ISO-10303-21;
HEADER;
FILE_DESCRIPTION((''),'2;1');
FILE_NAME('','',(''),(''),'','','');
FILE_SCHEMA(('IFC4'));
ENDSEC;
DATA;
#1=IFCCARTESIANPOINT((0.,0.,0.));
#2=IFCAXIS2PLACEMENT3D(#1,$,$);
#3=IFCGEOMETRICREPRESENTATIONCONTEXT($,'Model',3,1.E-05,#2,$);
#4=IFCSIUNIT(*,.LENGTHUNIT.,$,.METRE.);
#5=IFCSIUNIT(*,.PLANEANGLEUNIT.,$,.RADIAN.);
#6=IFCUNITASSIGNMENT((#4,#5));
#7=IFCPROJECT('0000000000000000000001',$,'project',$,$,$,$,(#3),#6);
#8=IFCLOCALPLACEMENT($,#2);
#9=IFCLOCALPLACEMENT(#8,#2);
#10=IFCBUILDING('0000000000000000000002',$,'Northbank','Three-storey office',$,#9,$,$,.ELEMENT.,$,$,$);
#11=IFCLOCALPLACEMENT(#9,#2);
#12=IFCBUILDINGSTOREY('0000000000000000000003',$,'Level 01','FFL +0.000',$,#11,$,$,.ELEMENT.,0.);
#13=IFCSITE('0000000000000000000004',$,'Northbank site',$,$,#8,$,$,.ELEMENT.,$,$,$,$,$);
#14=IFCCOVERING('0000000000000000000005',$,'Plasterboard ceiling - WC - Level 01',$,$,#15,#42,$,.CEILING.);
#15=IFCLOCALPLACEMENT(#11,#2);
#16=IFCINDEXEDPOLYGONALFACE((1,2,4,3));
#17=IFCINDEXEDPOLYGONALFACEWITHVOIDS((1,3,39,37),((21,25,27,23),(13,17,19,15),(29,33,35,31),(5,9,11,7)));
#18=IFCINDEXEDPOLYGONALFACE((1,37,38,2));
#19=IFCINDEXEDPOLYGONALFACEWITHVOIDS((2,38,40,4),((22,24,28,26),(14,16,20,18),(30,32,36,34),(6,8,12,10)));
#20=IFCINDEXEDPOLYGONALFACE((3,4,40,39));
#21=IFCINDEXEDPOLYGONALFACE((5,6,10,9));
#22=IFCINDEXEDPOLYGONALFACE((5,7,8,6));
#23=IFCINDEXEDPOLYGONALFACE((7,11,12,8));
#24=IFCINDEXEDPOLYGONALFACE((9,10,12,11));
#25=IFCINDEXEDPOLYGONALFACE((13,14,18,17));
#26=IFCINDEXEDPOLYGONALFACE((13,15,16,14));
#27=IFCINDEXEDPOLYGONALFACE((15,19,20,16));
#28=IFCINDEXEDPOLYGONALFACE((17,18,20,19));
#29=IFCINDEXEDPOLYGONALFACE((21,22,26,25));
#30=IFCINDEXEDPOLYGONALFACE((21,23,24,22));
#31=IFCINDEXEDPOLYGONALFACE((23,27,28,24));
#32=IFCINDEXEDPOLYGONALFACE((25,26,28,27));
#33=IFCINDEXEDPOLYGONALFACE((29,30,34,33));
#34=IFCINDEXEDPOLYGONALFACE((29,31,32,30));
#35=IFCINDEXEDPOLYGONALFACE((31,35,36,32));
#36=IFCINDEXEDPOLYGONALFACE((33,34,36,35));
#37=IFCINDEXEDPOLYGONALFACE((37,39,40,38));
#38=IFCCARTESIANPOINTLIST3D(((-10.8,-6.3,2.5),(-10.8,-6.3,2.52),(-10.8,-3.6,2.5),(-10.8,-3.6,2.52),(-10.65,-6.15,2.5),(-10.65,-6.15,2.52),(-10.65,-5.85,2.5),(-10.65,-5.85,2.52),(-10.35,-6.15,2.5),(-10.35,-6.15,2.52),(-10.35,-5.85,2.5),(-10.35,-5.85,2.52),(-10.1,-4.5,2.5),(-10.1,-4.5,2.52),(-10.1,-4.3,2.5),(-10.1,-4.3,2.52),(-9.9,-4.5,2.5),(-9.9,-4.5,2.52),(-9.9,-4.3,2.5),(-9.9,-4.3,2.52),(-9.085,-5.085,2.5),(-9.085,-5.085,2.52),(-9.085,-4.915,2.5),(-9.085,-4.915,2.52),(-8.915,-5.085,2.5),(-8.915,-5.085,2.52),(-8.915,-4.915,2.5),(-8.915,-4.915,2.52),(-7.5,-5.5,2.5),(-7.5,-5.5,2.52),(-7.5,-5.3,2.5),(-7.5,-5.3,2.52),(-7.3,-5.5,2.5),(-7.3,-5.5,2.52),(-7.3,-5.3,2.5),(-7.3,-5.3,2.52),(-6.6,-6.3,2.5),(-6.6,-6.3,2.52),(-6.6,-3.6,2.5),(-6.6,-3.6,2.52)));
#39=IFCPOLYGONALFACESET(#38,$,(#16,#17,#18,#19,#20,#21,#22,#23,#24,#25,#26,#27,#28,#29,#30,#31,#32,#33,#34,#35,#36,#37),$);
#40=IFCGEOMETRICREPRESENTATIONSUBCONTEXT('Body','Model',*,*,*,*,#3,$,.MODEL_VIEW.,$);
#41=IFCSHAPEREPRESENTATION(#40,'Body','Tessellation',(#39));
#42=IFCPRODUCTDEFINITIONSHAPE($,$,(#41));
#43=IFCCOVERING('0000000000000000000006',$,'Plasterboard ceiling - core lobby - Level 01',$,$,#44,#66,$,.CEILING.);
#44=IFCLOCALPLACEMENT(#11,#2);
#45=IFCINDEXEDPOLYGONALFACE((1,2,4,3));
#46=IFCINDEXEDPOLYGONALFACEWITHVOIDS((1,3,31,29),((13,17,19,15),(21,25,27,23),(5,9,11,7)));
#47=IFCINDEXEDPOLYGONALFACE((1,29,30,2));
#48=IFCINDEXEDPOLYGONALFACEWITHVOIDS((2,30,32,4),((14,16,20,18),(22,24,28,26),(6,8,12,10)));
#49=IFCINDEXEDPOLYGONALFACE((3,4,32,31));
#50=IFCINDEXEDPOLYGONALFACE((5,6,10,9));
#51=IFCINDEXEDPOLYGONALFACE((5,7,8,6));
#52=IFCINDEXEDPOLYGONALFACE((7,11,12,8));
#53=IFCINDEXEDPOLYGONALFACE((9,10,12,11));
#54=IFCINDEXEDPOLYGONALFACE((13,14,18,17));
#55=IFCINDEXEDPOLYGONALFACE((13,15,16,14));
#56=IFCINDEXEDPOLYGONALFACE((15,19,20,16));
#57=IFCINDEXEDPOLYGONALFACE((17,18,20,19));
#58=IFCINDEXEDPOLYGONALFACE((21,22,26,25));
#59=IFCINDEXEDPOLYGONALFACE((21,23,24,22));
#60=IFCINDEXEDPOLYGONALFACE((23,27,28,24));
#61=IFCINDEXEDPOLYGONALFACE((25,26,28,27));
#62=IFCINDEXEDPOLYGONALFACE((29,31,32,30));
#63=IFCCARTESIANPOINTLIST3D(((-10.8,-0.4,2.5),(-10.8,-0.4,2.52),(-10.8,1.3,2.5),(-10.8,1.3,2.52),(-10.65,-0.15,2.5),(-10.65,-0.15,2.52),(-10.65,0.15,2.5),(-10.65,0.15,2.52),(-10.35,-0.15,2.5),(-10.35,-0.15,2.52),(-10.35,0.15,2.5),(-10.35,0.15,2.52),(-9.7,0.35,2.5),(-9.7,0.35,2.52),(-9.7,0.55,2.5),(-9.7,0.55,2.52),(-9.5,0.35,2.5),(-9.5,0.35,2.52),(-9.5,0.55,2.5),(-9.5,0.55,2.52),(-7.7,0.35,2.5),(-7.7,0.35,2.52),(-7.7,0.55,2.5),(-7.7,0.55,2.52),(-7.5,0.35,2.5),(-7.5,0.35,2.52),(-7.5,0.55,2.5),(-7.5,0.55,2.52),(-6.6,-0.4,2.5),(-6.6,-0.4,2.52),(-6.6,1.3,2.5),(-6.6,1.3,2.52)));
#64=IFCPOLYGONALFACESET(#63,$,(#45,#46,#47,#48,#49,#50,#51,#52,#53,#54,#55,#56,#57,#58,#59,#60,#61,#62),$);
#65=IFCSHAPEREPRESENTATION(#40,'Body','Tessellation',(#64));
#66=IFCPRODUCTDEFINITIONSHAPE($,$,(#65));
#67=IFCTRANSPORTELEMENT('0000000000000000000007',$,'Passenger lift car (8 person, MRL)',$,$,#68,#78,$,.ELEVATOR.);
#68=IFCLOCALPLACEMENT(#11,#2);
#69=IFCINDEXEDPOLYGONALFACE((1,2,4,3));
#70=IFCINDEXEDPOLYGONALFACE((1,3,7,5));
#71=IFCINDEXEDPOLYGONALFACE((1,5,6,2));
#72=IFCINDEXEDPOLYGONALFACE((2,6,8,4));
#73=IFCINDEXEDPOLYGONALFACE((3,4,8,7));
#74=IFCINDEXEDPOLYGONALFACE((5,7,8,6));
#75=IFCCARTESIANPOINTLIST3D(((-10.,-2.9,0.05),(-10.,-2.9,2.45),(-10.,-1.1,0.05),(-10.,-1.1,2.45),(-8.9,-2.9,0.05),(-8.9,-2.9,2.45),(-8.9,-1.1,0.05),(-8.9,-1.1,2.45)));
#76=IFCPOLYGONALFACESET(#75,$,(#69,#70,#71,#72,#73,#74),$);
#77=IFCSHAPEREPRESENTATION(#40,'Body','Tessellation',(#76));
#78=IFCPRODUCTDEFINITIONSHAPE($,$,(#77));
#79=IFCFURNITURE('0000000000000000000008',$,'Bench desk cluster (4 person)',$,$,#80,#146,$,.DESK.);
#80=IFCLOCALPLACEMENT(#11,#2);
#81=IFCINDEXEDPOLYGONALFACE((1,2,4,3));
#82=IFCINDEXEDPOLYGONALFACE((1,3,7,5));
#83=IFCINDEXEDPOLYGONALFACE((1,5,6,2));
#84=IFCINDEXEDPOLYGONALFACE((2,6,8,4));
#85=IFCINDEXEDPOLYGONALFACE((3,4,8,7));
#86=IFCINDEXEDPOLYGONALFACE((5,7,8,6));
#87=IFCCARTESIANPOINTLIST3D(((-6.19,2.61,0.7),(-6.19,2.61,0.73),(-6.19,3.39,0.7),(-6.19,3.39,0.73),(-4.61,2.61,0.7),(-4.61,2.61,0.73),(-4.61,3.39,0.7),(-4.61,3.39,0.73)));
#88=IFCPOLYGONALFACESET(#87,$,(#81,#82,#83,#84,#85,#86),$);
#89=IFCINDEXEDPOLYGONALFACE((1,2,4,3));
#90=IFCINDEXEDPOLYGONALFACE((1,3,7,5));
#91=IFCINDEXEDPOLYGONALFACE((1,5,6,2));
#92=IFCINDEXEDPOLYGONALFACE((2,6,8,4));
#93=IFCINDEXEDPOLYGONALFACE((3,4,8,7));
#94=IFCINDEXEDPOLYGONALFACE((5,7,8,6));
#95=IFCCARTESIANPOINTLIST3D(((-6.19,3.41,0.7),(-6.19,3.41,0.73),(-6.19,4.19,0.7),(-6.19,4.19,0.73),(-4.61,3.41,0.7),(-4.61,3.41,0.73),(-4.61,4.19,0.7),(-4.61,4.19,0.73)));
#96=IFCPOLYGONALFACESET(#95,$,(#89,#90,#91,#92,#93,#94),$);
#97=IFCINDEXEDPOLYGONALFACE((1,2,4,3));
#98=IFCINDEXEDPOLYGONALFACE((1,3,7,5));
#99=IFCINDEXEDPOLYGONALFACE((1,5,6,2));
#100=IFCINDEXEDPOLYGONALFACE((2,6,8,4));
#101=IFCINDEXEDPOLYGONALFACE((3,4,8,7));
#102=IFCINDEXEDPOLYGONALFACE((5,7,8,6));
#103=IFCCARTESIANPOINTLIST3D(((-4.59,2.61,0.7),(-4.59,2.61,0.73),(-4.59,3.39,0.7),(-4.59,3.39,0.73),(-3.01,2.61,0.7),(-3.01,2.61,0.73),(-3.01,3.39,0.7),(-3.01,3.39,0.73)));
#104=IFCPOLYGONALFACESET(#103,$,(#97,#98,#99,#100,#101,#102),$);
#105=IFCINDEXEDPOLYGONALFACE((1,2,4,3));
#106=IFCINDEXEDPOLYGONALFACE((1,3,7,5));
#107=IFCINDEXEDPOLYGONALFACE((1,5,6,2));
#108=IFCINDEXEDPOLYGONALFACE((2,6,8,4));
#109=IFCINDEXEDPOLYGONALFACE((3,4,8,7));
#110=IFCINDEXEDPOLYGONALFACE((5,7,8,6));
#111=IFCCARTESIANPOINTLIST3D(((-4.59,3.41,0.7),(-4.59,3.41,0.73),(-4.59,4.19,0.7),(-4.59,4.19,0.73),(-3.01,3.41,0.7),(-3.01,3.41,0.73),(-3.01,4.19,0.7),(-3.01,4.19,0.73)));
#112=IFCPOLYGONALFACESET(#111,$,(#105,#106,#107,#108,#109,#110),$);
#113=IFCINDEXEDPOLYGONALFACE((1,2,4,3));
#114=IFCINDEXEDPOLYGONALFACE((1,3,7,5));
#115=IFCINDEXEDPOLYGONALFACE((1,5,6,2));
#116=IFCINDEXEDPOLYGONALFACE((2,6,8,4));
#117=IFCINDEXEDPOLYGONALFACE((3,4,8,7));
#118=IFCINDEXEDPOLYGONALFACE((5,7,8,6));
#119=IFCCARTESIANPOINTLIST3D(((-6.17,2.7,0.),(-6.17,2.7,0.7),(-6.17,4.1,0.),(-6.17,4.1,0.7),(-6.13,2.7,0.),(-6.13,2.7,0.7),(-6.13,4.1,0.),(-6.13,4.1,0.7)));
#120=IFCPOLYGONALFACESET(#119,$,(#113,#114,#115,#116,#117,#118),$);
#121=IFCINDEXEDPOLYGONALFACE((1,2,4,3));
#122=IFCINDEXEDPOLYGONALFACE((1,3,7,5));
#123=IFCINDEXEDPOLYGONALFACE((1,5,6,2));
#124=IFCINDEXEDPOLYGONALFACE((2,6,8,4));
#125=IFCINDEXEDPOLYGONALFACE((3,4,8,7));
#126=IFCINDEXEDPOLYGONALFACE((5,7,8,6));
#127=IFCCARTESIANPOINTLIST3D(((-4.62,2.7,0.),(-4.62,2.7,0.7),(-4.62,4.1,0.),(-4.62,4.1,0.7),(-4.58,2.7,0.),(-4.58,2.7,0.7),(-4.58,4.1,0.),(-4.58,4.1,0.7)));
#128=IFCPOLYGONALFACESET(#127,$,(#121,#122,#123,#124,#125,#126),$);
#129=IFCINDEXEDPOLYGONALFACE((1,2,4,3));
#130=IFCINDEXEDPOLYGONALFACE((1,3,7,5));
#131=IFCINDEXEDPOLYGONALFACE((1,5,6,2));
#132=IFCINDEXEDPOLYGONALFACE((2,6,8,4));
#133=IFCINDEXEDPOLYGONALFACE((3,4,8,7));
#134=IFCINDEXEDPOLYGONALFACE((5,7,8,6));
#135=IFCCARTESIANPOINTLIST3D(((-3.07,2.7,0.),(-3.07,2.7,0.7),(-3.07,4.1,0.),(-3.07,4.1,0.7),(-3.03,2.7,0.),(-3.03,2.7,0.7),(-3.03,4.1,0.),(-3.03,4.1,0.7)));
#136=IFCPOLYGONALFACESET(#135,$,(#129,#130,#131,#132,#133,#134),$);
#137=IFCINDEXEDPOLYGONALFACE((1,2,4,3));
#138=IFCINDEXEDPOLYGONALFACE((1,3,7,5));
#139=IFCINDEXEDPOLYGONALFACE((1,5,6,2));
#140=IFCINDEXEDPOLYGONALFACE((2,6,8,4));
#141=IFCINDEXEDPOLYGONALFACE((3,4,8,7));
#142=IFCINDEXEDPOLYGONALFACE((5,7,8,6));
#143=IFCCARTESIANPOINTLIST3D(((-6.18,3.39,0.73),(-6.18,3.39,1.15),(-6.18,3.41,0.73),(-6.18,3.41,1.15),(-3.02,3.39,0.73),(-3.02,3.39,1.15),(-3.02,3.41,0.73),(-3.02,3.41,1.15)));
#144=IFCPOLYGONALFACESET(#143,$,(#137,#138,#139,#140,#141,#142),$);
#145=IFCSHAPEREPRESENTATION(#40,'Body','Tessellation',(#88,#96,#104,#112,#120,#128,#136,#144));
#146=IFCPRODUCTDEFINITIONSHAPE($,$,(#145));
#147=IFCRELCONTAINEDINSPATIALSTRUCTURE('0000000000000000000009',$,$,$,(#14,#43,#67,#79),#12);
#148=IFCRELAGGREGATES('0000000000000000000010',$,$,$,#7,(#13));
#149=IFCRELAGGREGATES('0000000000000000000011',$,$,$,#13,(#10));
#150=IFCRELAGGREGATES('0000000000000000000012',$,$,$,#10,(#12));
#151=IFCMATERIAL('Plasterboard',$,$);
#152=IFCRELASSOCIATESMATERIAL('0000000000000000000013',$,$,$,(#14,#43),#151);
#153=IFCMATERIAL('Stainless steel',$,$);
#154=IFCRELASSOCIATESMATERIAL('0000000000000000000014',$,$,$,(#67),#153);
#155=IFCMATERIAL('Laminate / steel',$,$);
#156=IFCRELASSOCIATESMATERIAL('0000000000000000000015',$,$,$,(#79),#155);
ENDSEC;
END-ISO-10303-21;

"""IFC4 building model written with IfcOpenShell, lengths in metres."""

from ifc_helpers import new_model, si_unit, frame, origin, place, context, subcontext, project, spatial, polyline, rectangle, outline, extrude, material, element, save


model = new_model("IFC4")

# Units and contexts
model_context = context("Model", 3, precision=1e-05, world=origin())
body_context = subcontext(model_context, "Body", "Model", "MODEL_VIEW")
ifc_project = project(units=[si_unit("LENGTHUNIT", "METRE"), si_unit("PLANEANGLEUNIT", "RADIAN")], contexts=[model_context])

# Site, building, storey
site_placement = place(None, origin())
site = spatial("IfcSite", under=ifc_project, at=site_placement, Name="Northbank site", CompositionType="ELEMENT")
building_placement = place(site_placement, origin())
building = spatial("IfcBuilding", under=site, at=building_placement, Name="Northbank", Description="Three-storey office", CompositionType="ELEMENT")
storey_placement = place(building_placement, origin())
storey = spatial("IfcBuildingStorey", under=building, at=storey_placement, Name="Level 01", Description="FFL +0.000", CompositionType="ELEMENT", Elevation=0.0)

# Coverings
ifc_material_1 = material(Name="Plasterboard")
covering_1_placement = place(storey_placement, origin())
element("IfcCovering", 1, at=covering_1_placement, inside=storey, material=ifc_material_1, Name="Plasterboard ceiling - WC - Level 01", PredefinedType="CEILING", context=body_context, shape_type="SweptSolid", body=[
    extrude(outline(polyline([(-10.8, -6.3), (-6.6, -6.3), (-6.6, -3.6), (-10.8, -3.6), (-10.8, -6.3)]), holes=[polyline([(-9.085, -5.085), (-9.085, -4.915), (-8.915, -4.915), (-8.915, -5.085), (-9.085, -5.085)]), polyline([(-10.1, -4.5), (-10.1, -4.3), (-9.9, -4.3), (-9.9, -4.5), (-10.1, -4.5)]), polyline([(-7.5, -5.5), (-7.5, -5.3), (-7.3, -5.3), (-7.3, -5.5), (-7.5, -5.5)]), polyline([(-10.65, -6.15), (-10.65, -5.85), (-10.35, -5.85), (-10.35, -6.15), (-10.65, -6.15)])]), frame((0.0, 0.0, 2.5)), (0.0, 0.0, 1.0), 0.02),
])
covering_2_placement = place(storey_placement, origin())
element("IfcCovering", 2, at=covering_2_placement, inside=storey, material=ifc_material_1, Name="Plasterboard ceiling - core lobby - Level 01", PredefinedType="CEILING", context=body_context, shape_type="SweptSolid", body=[
    extrude(outline(polyline([(-10.8, -0.4), (-6.6, -0.4), (-6.6, 1.3), (-10.8, 1.3), (-10.8, -0.4)]), holes=[polyline([(-9.7, 0.35), (-9.7, 0.55), (-9.5, 0.55), (-9.5, 0.35), (-9.7, 0.35)]), polyline([(-7.7, 0.35), (-7.7, 0.55), (-7.5, 0.55), (-7.5, 0.35), (-7.7, 0.35)]), polyline([(-10.65, -0.15), (-10.65, 0.15), (-10.35, 0.15), (-10.35, -0.15), (-10.65, -0.15)])]), frame((0.0, 0.0, 2.5)), (0.0, 0.0, 1.0), 0.02),
])

# Transport element
ifc_material_2 = material(Name="Stainless steel")
transport_element_placement = place(storey_placement, origin())
element("IfcTransportElement", 3, at=transport_element_placement, inside=storey, material=ifc_material_2, Name="Passenger lift car (8 person, MRL)", PredefinedType="ELEVATOR", context=body_context, shape_type="SweptSolid", body=[
    extrude(rectangle(XDim=1.1, YDim=1.8), frame((-9.45, -2.0, 0.05)), (0.0, 0.0, 1.0), 2.4),
])

# Furniture
ifc_material_3 = material(Name="Laminate / steel")
furniture_1_placement = place(storey_placement, origin())
element("IfcFurniture", 4, at=furniture_1_placement, inside=storey, material=ifc_material_3, Name="Bench desk cluster (4 person)", PredefinedType="DESK", context=body_context, shape_type="SweptSolid", body=[
    extrude(rectangle(XDim=1.58, YDim=0.78), frame((-5.4, 3.0, 0.7)), (0.0, 0.0, 1.0), 0.03),
    extrude(rectangle(XDim=1.58, YDim=0.78), frame((-5.4, 3.8, 0.7)), (0.0, 0.0, 1.0), 0.03),
    extrude(rectangle(XDim=1.58, YDim=0.78), frame((-3.8, 3.0, 0.7)), (0.0, 0.0, 1.0), 0.03),
    extrude(rectangle(XDim=1.58, YDim=0.78), frame((-3.8, 3.8, 0.7)), (0.0, 0.0, 1.0), 0.03),
    extrude(rectangle(XDim=0.04, YDim=1.4), frame((-6.15, 3.4, 0.0)), (0.0, 0.0, 1.0), 0.7),
    extrude(rectangle(XDim=0.04, YDim=1.4), frame((-4.6, 3.4, 0.0)), (0.0, 0.0, 1.0), 0.7),
    extrude(rectangle(XDim=0.04, YDim=1.4), frame((-3.05, 3.4, 0.0)), (0.0, 0.0, 1.0), 0.7),
    extrude(rectangle(XDim=3.16, YDim=0.02), frame((-4.6, 3.4, 0.73)), (0.0, 0.0, 1.0), 0.42),
])

save(model, "model.ifc")
